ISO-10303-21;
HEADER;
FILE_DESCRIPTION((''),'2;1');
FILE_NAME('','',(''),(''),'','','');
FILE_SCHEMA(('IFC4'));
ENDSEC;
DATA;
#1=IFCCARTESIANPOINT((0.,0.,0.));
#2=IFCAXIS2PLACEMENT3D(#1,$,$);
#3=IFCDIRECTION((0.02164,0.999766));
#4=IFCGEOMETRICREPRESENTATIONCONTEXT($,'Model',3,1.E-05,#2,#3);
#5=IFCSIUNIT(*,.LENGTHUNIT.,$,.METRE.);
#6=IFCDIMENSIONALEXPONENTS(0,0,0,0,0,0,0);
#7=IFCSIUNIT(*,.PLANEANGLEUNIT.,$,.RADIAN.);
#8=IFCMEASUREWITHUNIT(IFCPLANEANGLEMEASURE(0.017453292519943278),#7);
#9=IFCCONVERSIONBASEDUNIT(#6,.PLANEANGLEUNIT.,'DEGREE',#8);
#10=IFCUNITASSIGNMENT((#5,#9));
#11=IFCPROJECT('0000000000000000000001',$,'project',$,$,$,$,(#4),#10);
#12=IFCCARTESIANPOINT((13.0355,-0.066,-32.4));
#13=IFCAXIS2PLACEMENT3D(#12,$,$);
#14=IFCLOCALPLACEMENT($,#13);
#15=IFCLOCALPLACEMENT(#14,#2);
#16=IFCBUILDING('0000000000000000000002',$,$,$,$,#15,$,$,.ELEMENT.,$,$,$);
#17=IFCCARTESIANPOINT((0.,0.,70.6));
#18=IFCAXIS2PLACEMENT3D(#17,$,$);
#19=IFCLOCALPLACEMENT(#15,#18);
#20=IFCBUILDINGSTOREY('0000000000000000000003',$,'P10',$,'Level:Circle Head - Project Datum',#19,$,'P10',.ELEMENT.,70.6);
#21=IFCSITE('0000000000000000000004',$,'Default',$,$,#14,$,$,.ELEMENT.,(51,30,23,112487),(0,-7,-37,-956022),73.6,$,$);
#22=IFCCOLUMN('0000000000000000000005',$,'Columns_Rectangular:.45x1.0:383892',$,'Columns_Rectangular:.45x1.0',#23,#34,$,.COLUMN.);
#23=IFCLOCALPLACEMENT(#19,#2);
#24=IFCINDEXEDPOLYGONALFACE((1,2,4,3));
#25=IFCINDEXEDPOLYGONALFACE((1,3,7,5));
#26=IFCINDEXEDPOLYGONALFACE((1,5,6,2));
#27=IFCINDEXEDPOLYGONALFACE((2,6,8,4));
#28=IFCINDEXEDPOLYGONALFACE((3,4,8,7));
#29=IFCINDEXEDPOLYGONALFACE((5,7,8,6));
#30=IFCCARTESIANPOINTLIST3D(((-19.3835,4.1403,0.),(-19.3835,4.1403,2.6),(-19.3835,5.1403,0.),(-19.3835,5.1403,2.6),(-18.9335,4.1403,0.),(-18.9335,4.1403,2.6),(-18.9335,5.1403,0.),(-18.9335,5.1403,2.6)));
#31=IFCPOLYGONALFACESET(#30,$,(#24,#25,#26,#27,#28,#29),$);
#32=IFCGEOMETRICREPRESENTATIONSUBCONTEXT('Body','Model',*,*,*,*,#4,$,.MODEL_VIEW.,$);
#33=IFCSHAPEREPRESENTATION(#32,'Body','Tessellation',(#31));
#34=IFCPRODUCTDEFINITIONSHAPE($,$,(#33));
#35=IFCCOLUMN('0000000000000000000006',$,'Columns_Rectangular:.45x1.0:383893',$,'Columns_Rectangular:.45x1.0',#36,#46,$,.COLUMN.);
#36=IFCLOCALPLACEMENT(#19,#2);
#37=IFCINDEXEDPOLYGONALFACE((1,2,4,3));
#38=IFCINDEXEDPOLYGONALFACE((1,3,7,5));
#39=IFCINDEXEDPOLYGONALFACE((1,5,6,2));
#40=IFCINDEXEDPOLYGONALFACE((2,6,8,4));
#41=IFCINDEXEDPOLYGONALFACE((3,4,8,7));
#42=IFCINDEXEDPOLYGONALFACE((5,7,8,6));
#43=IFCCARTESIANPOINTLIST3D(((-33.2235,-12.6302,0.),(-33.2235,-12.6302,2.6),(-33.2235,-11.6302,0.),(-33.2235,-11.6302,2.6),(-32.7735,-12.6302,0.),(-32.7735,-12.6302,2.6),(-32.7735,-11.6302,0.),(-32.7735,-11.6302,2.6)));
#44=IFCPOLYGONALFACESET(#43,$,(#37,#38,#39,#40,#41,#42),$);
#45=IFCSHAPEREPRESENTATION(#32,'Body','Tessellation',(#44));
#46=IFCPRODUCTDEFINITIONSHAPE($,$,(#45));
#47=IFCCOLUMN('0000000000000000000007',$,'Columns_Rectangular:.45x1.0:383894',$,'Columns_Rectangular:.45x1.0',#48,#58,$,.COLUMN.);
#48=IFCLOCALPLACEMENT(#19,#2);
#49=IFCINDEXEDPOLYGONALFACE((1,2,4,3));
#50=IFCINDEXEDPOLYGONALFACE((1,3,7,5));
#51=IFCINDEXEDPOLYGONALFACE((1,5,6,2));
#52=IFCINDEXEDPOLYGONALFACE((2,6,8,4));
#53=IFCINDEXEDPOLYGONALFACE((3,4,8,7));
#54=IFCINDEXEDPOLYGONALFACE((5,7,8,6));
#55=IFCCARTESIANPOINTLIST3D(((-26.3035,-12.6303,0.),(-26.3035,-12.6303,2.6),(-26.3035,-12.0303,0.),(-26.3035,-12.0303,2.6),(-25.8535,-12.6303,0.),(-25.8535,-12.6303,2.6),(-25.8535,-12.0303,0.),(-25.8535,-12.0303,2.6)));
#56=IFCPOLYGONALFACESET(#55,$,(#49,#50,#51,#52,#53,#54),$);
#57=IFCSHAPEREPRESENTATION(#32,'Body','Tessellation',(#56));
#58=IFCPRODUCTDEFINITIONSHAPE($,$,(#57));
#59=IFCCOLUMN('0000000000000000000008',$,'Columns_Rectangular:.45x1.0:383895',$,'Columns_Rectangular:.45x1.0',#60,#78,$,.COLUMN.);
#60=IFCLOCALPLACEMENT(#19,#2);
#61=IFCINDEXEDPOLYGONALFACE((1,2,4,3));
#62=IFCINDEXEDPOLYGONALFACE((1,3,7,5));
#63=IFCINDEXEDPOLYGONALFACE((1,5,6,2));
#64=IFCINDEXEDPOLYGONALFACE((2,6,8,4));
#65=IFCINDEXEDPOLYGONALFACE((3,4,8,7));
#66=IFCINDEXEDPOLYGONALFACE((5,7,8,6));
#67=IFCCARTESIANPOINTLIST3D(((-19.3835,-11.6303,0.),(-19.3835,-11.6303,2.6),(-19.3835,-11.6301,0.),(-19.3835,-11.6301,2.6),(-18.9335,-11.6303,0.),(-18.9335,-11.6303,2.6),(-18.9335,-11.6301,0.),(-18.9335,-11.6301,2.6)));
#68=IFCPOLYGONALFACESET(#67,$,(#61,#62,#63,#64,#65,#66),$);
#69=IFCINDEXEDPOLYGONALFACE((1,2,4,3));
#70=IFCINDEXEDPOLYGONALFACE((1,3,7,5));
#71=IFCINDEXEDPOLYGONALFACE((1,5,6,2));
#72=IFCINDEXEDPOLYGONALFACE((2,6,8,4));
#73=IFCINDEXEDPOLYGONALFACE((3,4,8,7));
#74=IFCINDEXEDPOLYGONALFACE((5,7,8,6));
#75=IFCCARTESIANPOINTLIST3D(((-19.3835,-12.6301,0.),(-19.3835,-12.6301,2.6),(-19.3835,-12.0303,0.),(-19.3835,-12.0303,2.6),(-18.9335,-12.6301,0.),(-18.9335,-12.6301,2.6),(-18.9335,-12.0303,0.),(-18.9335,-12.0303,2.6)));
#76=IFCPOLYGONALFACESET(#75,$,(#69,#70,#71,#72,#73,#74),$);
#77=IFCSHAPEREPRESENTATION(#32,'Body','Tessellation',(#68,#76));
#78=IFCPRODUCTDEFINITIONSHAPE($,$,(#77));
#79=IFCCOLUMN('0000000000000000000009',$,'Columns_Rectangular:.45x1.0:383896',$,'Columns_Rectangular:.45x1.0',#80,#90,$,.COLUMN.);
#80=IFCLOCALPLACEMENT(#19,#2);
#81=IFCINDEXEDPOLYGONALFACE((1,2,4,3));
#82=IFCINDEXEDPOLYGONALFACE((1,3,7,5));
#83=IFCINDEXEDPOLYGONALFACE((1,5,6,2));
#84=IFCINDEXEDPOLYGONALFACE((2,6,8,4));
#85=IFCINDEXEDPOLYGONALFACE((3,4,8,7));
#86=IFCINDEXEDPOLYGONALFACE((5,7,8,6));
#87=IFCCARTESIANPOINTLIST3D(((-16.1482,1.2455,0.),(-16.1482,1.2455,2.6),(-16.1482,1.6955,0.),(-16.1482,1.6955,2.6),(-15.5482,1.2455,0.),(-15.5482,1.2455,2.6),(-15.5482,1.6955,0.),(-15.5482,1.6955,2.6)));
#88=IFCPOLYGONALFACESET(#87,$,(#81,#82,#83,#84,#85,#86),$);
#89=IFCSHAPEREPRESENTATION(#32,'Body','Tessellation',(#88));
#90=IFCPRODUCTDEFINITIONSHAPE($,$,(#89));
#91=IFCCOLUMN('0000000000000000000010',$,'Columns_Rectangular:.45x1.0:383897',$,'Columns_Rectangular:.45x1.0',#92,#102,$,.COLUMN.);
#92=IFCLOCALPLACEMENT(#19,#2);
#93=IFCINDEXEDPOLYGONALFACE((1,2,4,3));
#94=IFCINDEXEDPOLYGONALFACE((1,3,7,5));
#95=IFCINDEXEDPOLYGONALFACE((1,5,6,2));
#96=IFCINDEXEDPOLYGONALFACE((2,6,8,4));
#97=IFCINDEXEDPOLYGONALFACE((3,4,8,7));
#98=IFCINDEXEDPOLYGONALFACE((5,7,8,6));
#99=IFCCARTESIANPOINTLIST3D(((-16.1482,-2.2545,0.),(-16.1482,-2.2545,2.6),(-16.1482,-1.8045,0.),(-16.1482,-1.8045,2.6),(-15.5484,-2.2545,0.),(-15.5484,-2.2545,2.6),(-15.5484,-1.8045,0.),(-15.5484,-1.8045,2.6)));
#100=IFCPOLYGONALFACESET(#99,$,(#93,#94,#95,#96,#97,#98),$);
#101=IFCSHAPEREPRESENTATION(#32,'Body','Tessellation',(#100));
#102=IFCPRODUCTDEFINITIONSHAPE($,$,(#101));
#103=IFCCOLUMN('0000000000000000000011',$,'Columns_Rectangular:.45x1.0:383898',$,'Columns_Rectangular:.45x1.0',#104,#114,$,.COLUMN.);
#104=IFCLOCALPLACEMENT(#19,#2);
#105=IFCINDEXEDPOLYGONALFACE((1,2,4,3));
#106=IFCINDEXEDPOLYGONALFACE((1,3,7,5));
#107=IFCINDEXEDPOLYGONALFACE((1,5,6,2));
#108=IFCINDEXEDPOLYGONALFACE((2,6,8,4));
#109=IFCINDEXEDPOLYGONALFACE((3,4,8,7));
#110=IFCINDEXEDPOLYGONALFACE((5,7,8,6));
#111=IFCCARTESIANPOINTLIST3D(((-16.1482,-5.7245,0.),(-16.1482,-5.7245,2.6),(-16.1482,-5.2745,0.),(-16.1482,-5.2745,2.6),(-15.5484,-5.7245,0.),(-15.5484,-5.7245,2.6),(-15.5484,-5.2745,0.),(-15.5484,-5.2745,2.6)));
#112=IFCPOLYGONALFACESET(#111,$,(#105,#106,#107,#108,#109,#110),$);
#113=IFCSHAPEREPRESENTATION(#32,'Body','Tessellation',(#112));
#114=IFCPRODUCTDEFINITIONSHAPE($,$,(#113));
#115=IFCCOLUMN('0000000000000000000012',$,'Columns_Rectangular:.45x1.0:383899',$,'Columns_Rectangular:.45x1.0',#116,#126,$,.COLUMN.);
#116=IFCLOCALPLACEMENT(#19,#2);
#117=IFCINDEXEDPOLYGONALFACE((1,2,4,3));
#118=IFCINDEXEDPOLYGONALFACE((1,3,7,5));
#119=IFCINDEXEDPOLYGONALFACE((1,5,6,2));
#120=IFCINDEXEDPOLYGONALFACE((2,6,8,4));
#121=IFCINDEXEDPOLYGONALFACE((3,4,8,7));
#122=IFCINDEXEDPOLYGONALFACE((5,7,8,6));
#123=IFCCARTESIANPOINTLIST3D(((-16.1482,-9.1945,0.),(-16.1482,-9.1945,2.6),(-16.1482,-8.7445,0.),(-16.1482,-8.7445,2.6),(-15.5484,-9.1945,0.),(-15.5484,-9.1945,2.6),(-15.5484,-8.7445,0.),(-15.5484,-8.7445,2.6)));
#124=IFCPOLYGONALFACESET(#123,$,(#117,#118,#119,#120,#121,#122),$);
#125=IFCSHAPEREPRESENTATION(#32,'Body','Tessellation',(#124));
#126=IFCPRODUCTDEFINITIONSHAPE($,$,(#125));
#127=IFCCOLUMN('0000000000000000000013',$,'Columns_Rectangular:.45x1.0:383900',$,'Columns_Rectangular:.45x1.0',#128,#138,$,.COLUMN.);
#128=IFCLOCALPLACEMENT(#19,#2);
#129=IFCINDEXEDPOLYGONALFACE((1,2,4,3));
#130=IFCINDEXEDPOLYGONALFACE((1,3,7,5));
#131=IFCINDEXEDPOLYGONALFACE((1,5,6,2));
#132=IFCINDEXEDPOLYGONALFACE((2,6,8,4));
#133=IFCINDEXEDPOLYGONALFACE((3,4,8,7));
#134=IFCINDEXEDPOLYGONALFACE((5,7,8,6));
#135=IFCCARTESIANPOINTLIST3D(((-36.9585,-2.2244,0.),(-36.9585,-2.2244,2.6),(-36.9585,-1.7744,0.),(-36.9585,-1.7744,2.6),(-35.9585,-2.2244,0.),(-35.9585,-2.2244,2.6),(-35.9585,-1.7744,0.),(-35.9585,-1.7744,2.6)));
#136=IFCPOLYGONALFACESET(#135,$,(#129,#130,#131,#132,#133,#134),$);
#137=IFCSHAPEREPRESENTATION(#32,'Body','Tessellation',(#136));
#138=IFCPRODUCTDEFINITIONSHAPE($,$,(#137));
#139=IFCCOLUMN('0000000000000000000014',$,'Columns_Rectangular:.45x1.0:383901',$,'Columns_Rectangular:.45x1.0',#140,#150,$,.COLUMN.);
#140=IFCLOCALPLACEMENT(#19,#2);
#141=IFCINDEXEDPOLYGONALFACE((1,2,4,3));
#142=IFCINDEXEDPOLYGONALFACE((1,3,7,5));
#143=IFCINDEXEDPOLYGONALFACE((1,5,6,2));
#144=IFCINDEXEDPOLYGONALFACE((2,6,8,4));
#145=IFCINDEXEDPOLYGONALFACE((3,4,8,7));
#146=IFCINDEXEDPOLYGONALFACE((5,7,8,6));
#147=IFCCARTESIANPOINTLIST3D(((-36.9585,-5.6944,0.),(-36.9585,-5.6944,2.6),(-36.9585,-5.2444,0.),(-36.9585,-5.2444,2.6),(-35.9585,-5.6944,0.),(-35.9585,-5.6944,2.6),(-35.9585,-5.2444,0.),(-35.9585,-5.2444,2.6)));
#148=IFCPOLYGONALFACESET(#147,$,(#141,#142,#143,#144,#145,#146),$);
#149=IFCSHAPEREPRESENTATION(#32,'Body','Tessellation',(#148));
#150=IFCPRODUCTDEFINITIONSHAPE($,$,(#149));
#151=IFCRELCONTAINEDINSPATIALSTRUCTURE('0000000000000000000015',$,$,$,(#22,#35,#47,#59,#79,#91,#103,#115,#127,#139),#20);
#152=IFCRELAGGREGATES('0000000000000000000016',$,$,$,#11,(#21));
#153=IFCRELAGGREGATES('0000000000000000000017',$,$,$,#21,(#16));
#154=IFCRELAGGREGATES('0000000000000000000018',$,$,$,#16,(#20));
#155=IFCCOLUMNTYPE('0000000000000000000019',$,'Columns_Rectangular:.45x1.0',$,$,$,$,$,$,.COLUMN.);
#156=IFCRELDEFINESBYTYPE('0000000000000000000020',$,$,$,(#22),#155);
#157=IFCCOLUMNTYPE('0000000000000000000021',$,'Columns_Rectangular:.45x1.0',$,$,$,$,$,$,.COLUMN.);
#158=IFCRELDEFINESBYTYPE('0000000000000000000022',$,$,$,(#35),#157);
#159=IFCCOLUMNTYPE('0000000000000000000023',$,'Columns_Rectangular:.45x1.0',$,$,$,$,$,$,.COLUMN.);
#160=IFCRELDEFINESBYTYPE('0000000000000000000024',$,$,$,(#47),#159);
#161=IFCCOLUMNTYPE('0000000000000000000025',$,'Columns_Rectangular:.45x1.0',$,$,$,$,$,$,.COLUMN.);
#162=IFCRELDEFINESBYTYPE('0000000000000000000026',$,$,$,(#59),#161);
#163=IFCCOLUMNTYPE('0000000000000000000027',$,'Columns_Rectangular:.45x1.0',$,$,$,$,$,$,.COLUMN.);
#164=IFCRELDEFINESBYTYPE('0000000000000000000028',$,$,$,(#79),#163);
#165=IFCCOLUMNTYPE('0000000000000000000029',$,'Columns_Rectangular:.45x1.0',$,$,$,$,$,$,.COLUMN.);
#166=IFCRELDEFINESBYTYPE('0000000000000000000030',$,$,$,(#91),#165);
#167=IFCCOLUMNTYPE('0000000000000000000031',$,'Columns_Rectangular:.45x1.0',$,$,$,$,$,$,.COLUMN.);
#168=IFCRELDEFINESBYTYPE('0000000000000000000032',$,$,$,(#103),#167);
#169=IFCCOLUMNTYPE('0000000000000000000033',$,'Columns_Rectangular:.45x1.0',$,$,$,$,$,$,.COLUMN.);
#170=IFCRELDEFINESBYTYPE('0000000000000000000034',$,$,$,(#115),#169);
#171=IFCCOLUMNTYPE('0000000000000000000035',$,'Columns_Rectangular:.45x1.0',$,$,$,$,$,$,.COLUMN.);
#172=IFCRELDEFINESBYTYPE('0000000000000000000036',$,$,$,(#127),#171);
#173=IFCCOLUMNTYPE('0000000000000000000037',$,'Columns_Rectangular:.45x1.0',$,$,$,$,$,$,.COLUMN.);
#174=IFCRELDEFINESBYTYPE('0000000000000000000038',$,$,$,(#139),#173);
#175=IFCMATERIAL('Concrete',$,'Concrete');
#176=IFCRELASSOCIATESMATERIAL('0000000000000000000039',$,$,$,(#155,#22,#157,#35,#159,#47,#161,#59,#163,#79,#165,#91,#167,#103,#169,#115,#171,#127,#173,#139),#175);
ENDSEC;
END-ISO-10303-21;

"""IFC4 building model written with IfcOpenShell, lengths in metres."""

from ifc_helpers import new_model, entity, si_unit, converted_unit, direction, frame, origin, place, context, subcontext, project, spatial, indexed_curve, outline, extrude, source, transform, mapped, material, type_object, type_shapes, element, save


model = new_model("IFC4")

# Units and contexts
model_context = context("Model", 3, precision=1e-05, world=origin(), true_north=direction((0.02164, 0.999766)))
body_context = subcontext(model_context, "Body", "Model", "MODEL_VIEW")
ifc_project = project(units=[si_unit("LENGTHUNIT", "METRE"), converted_unit("PLANEANGLEUNIT", "DEGREE", entity("IfcPlaneAngleMeasure", 0.017453292519943278), si_unit("PLANEANGLEUNIT", "RADIAN"), dimensions=[0, 0, 0, 0, 0, 0, 0])], contexts=[model_context])

# Site, building, storey
site_placement = place(None, frame((13.0355, -0.066, -32.4)))
site = spatial("IfcSite", under=ifc_project, at=site_placement, Name="Default", CompositionType="ELEMENT", RefLatitude=(51, 30, 23, 112487), RefLongitude=(0, -7, -37, -956022), RefElevation=73.6)
building_placement = place(site_placement, origin())
building = spatial("IfcBuilding", under=site, at=building_placement, CompositionType="ELEMENT")
storey_placement = place(building_placement, frame((0.0, 0.0, 70.6)))
storey = spatial("IfcBuildingStorey", under=building, at=storey_placement, Name="P10", ObjectType="Level:Circle Head - Project Datum", LongName="P10", CompositionType="ELEMENT", Elevation=70.6)

# Columns
ifc_material = material(Name="Concrete", Category="Concrete")
column_type_1 = type_object("IfcColumnType", Name="Columns_Rectangular:.45x1.0", PredefinedType="COLUMN", material=ifc_material)
shared_shape_1 = source(origin(), body_context, "Body", "SweptSolid", [
    extrude(outline(indexed_curve([(-0.5, -0.225), (0.5, -0.225), (0.5, 0.225), (-0.5, 0.225), (-0.5, -0.225)], self_intersect=False)), frame((-19.1585, 4.6403, 70.6), z_axis=(0.0, 0.0, 1.0), x_axis=(0.000016, 1.0, 0.0)), (0.0, 0.0, 1.0), 2.6),
])
type_shapes(column_type_1, [shared_shape_1])
column_1_placement = place(storey_placement, frame((0.0, 0.0, -70.6)))
element("IfcColumn", 1, at=column_1_placement, inside=storey, type_object=column_type_1, material=ifc_material, Name="Columns_Rectangular:.45x1.0:383892", ObjectType="Columns_Rectangular:.45x1.0", PredefinedType="COLUMN", context=body_context, shape_type="MappedRepresentation", body=[
    mapped(shared_shape_1, transform((0.0, 0.0, 0.0), scale=1.0)),
])
column_type_2 = type_object("IfcColumnType", Name="Columns_Rectangular:.45x1.0", PredefinedType="COLUMN", material=ifc_material)
shared_shape_2 = source(origin(), body_context, "Body", "SweptSolid", [
    extrude(outline(indexed_curve([(-0.5, -0.225), (0.5, -0.225), (0.5, 0.225), (-0.5, 0.225), (-0.5, -0.225)], self_intersect=False)), frame((-32.9985, -12.1302, 70.6), z_axis=(0.0, 0.0, 1.0), x_axis=(-0.000005, 1.0, 0.0)), (0.0, 0.0, 1.0), 2.6),
])
type_shapes(column_type_2, [shared_shape_2])
column_2_placement = place(storey_placement, frame((0.0, 0.0, -70.6)))
element("IfcColumn", 2, at=column_2_placement, inside=storey, type_object=column_type_2, material=ifc_material, Name="Columns_Rectangular:.45x1.0:383893", ObjectType="Columns_Rectangular:.45x1.0", PredefinedType="COLUMN", context=body_context, shape_type="MappedRepresentation", body=[
    mapped(shared_shape_2, transform((0.0, 0.0, 0.0), scale=1.0)),
])
column_type_3 = type_object("IfcColumnType", Name="Columns_Rectangular:.45x1.0", PredefinedType="COLUMN", material=ifc_material)
shared_shape_3 = source(origin(), body_context, "Body", "SweptSolid", [
    extrude(outline(indexed_curve([(-0.3, -0.225), (0.3, -0.225), (0.3, 0.225), (-0.3, 0.225), (-0.3, -0.225)], self_intersect=False)), frame((-26.0785, -12.3303, 70.6), z_axis=(0.0, 0.0, 1.0), x_axis=(0.000011, 1.0, 0.0)), (0.0, 0.0, 1.0), 2.6),
])
type_shapes(column_type_3, [shared_shape_3])
column_3_placement = place(storey_placement, frame((0.0, 0.0, -70.6)))
element("IfcColumn", 3, at=column_3_placement, inside=storey, type_object=column_type_3, material=ifc_material, Name="Columns_Rectangular:.45x1.0:383894", ObjectType="Columns_Rectangular:.45x1.0", PredefinedType="COLUMN", context=body_context, shape_type="MappedRepresentation", body=[
    mapped(shared_shape_3, transform((0.0, 0.0, 0.0), scale=1.0)),
])
column_type_4 = type_object("IfcColumnType", Name="Columns_Rectangular:.45x1.0", PredefinedType="COLUMN", material=ifc_material)
shared_shape_4 = source(origin(), body_context, "Body", "SweptSolid", [
    extrude(outline(indexed_curve([(-0.0001, -0.225), (0.0001, -0.225), (0.0001, 0.225), (-0.0001, 0.225), (-0.0001, -0.225)], self_intersect=False)), frame((-19.1585, -11.6302, 70.6), z_axis=(0.0, 0.0, 1.0), x_axis=(-0.000011, -1.0, 0.0)), (0.0, 0.0, 1.0), 2.6),
    extrude(outline(indexed_curve([(-0.2999, -0.225), (0.2999, -0.225), (0.2999, 0.225), (-0.2999, 0.225), (-0.2999, -0.225)], self_intersect=False)), frame((-19.1585, -12.3302, 70.6), z_axis=(0.0, 0.0, 1.0), x_axis=(0.000011, 1.0, 0.0)), (0.0, 0.0, 1.0), 2.6),
])
type_shapes(column_type_4, [shared_shape_4])
column_4_placement = place(storey_placement, frame((0.0, 0.0, -70.6)))
element("IfcColumn", 4, at=column_4_placement, inside=storey, type_object=column_type_4, material=ifc_material, Name="Columns_Rectangular:.45x1.0:383895", ObjectType="Columns_Rectangular:.45x1.0", PredefinedType="COLUMN", context=body_context, shape_type="MappedRepresentation", body=[
    mapped(shared_shape_4, transform((0.0, 0.0, 0.0), scale=1.0)),
])
column_type_5 = type_object("IfcColumnType", Name="Columns_Rectangular:.45x1.0", PredefinedType="COLUMN", material=ifc_material)
shared_shape_5 = source(origin(), body_context, "Body", "SweptSolid", [
    extrude(outline(indexed_curve([(-0.3, -0.225), (0.3, -0.225), (0.3, 0.225), (-0.3, 0.225), (-0.3, -0.225)], self_intersect=False)), frame((-15.8482, 1.4705, 70.6), z_axis=(0.0, 0.0, 1.0), x_axis=(-1.0, 0.0, 0.0)), (0.0, 0.0, 1.0), 2.6),
])
type_shapes(column_type_5, [shared_shape_5])
column_5_placement = place(storey_placement, frame((0.0, 0.0, -70.6)))
element("IfcColumn", 5, at=column_5_placement, inside=storey, type_object=column_type_5, material=ifc_material, Name="Columns_Rectangular:.45x1.0:383896", ObjectType="Columns_Rectangular:.45x1.0", PredefinedType="COLUMN", context=body_context, shape_type="MappedRepresentation", body=[
    mapped(shared_shape_5, transform((0.0, 0.0, 0.0), scale=1.0)),
])
column_type_6 = type_object("IfcColumnType", Name="Columns_Rectangular:.45x1.0", PredefinedType="COLUMN", material=ifc_material)
shared_shape_6 = source(origin(), body_context, "Body", "SweptSolid", [
    extrude(outline(indexed_curve([(-0.2999, -0.225), (0.2999, -0.225), (0.2999, 0.225), (-0.2999, 0.225), (-0.2999, -0.225)], self_intersect=False)), frame((-15.8483, -2.0295, 70.6), z_axis=(0.0, 0.0, 1.0), x_axis=(-1.0, 0.0, 0.0)), (0.0, 0.0, 1.0), 2.6),
])
type_shapes(column_type_6, [shared_shape_6])
column_6_placement = place(storey_placement, frame((0.0, 0.0, -70.6)))
element("IfcColumn", 6, at=column_6_placement, inside=storey, type_object=column_type_6, material=ifc_material, Name="Columns_Rectangular:.45x1.0:383897", ObjectType="Columns_Rectangular:.45x1.0", PredefinedType="COLUMN", context=body_context, shape_type="MappedRepresentation", body=[
    mapped(shared_shape_6, transform((0.0, 0.0, 0.0), scale=1.0)),
])
column_type_7 = type_object("IfcColumnType", Name="Columns_Rectangular:.45x1.0", PredefinedType="COLUMN", material=ifc_material)
shared_shape_7 = source(origin(), body_context, "Body", "SweptSolid", [
    extrude(outline(indexed_curve([(-0.2999, -0.225), (0.2999, -0.225), (0.2999, 0.225), (-0.2999, 0.225), (-0.2999, -0.225)], self_intersect=False)), frame((-15.8483, -5.4995, 70.6), z_axis=(0.0, 0.0, 1.0), x_axis=(-1.0, 0.0, 0.0)), (0.0, 0.0, 1.0), 2.6),
])
type_shapes(column_type_7, [shared_shape_7])
column_7_placement = place(storey_placement, frame((0.0, 0.0, -70.6)))
element("IfcColumn", 7, at=column_7_placement, inside=storey, type_object=column_type_7, material=ifc_material, Name="Columns_Rectangular:.45x1.0:383898", ObjectType="Columns_Rectangular:.45x1.0", PredefinedType="COLUMN", context=body_context, shape_type="MappedRepresentation", body=[
    mapped(shared_shape_7, transform((0.0, 0.0, 0.0), scale=1.0)),
])
column_type_8 = type_object("IfcColumnType", Name="Columns_Rectangular:.45x1.0", PredefinedType="COLUMN", material=ifc_material)
shared_shape_8 = source(origin(), body_context, "Body", "SweptSolid", [
    extrude(outline(indexed_curve([(-0.2999, -0.225), (0.2999, -0.225), (0.2999, 0.225), (-0.2999, 0.225), (-0.2999, -0.225)], self_intersect=False)), frame((-15.8483, -8.9695, 70.6), z_axis=(0.0, 0.0, 1.0), x_axis=(-1.0, 0.0, 0.0)), (0.0, 0.0, 1.0), 2.6),
])
type_shapes(column_type_8, [shared_shape_8])
column_8_placement = place(storey_placement, frame((0.0, 0.0, -70.6)))
element("IfcColumn", 8, at=column_8_placement, inside=storey, type_object=column_type_8, material=ifc_material, Name="Columns_Rectangular:.45x1.0:383899", ObjectType="Columns_Rectangular:.45x1.0", PredefinedType="COLUMN", context=body_context, shape_type="MappedRepresentation", body=[
    mapped(shared_shape_8, transform((0.0, 0.0, 0.0), scale=1.0)),
])
column_type_9 = type_object("IfcColumnType", Name="Columns_Rectangular:.45x1.0", PredefinedType="COLUMN", material=ifc_material)
shared_shape_9 = source(origin(), body_context, "Body", "SweptSolid", [
    extrude(outline(indexed_curve([(-1.3, -0.225), (1.3, -0.225), (1.3, 0.225), (-1.3, 0.225), (-1.3, -0.225)], self_intersect=False)), frame((-36.9585, -1.9994, 71.9), z_axis=(1.0, 0.0, 0.0), x_axis=(0.0, 0.0, 1.0)), (0.0, 0.0, 1.0), 1.0),
])
type_shapes(column_type_9, [shared_shape_9])
column_9_placement = place(storey_placement, frame((0.0, 0.0, -70.6)))
element("IfcColumn", 9, at=column_9_placement, inside=storey, type_object=column_type_9, material=ifc_material, Name="Columns_Rectangular:.45x1.0:383900", ObjectType="Columns_Rectangular:.45x1.0", PredefinedType="COLUMN", context=body_context, shape_type="MappedRepresentation", body=[
    mapped(shared_shape_9, transform((0.0, 0.0, 0.0), scale=1.0)),
])
column_type_10 = type_object("IfcColumnType", Name="Columns_Rectangular:.45x1.0", PredefinedType="COLUMN", material=ifc_material)
shared_shape_10 = source(origin(), body_context, "Body", "SweptSolid", [
    extrude(outline(indexed_curve([(-1.3, -0.225), (1.3, -0.225), (1.3, 0.225), (-1.3, 0.225), (-1.3, -0.225)], self_intersect=False)), frame((-36.9585, -5.4694, 71.9), z_axis=(1.0, 0.0, 0.0), x_axis=(0.0, 0.0, 1.0)), (0.0, 0.0, 1.0), 1.0),
])
type_shapes(column_type_10, [shared_shape_10])
column_10_placement = place(storey_placement, frame((0.0, 0.0, -70.6)))
element("IfcColumn", 10, at=column_10_placement, inside=storey, type_object=column_type_10, material=ifc_material, Name="Columns_Rectangular:.45x1.0:383901", ObjectType="Columns_Rectangular:.45x1.0", PredefinedType="COLUMN", context=body_context, shape_type="MappedRepresentation", body=[
    mapped(shared_shape_10, transform((0.0, 0.0, 0.0), scale=1.0)),
])

save(model, "model.ifc")
